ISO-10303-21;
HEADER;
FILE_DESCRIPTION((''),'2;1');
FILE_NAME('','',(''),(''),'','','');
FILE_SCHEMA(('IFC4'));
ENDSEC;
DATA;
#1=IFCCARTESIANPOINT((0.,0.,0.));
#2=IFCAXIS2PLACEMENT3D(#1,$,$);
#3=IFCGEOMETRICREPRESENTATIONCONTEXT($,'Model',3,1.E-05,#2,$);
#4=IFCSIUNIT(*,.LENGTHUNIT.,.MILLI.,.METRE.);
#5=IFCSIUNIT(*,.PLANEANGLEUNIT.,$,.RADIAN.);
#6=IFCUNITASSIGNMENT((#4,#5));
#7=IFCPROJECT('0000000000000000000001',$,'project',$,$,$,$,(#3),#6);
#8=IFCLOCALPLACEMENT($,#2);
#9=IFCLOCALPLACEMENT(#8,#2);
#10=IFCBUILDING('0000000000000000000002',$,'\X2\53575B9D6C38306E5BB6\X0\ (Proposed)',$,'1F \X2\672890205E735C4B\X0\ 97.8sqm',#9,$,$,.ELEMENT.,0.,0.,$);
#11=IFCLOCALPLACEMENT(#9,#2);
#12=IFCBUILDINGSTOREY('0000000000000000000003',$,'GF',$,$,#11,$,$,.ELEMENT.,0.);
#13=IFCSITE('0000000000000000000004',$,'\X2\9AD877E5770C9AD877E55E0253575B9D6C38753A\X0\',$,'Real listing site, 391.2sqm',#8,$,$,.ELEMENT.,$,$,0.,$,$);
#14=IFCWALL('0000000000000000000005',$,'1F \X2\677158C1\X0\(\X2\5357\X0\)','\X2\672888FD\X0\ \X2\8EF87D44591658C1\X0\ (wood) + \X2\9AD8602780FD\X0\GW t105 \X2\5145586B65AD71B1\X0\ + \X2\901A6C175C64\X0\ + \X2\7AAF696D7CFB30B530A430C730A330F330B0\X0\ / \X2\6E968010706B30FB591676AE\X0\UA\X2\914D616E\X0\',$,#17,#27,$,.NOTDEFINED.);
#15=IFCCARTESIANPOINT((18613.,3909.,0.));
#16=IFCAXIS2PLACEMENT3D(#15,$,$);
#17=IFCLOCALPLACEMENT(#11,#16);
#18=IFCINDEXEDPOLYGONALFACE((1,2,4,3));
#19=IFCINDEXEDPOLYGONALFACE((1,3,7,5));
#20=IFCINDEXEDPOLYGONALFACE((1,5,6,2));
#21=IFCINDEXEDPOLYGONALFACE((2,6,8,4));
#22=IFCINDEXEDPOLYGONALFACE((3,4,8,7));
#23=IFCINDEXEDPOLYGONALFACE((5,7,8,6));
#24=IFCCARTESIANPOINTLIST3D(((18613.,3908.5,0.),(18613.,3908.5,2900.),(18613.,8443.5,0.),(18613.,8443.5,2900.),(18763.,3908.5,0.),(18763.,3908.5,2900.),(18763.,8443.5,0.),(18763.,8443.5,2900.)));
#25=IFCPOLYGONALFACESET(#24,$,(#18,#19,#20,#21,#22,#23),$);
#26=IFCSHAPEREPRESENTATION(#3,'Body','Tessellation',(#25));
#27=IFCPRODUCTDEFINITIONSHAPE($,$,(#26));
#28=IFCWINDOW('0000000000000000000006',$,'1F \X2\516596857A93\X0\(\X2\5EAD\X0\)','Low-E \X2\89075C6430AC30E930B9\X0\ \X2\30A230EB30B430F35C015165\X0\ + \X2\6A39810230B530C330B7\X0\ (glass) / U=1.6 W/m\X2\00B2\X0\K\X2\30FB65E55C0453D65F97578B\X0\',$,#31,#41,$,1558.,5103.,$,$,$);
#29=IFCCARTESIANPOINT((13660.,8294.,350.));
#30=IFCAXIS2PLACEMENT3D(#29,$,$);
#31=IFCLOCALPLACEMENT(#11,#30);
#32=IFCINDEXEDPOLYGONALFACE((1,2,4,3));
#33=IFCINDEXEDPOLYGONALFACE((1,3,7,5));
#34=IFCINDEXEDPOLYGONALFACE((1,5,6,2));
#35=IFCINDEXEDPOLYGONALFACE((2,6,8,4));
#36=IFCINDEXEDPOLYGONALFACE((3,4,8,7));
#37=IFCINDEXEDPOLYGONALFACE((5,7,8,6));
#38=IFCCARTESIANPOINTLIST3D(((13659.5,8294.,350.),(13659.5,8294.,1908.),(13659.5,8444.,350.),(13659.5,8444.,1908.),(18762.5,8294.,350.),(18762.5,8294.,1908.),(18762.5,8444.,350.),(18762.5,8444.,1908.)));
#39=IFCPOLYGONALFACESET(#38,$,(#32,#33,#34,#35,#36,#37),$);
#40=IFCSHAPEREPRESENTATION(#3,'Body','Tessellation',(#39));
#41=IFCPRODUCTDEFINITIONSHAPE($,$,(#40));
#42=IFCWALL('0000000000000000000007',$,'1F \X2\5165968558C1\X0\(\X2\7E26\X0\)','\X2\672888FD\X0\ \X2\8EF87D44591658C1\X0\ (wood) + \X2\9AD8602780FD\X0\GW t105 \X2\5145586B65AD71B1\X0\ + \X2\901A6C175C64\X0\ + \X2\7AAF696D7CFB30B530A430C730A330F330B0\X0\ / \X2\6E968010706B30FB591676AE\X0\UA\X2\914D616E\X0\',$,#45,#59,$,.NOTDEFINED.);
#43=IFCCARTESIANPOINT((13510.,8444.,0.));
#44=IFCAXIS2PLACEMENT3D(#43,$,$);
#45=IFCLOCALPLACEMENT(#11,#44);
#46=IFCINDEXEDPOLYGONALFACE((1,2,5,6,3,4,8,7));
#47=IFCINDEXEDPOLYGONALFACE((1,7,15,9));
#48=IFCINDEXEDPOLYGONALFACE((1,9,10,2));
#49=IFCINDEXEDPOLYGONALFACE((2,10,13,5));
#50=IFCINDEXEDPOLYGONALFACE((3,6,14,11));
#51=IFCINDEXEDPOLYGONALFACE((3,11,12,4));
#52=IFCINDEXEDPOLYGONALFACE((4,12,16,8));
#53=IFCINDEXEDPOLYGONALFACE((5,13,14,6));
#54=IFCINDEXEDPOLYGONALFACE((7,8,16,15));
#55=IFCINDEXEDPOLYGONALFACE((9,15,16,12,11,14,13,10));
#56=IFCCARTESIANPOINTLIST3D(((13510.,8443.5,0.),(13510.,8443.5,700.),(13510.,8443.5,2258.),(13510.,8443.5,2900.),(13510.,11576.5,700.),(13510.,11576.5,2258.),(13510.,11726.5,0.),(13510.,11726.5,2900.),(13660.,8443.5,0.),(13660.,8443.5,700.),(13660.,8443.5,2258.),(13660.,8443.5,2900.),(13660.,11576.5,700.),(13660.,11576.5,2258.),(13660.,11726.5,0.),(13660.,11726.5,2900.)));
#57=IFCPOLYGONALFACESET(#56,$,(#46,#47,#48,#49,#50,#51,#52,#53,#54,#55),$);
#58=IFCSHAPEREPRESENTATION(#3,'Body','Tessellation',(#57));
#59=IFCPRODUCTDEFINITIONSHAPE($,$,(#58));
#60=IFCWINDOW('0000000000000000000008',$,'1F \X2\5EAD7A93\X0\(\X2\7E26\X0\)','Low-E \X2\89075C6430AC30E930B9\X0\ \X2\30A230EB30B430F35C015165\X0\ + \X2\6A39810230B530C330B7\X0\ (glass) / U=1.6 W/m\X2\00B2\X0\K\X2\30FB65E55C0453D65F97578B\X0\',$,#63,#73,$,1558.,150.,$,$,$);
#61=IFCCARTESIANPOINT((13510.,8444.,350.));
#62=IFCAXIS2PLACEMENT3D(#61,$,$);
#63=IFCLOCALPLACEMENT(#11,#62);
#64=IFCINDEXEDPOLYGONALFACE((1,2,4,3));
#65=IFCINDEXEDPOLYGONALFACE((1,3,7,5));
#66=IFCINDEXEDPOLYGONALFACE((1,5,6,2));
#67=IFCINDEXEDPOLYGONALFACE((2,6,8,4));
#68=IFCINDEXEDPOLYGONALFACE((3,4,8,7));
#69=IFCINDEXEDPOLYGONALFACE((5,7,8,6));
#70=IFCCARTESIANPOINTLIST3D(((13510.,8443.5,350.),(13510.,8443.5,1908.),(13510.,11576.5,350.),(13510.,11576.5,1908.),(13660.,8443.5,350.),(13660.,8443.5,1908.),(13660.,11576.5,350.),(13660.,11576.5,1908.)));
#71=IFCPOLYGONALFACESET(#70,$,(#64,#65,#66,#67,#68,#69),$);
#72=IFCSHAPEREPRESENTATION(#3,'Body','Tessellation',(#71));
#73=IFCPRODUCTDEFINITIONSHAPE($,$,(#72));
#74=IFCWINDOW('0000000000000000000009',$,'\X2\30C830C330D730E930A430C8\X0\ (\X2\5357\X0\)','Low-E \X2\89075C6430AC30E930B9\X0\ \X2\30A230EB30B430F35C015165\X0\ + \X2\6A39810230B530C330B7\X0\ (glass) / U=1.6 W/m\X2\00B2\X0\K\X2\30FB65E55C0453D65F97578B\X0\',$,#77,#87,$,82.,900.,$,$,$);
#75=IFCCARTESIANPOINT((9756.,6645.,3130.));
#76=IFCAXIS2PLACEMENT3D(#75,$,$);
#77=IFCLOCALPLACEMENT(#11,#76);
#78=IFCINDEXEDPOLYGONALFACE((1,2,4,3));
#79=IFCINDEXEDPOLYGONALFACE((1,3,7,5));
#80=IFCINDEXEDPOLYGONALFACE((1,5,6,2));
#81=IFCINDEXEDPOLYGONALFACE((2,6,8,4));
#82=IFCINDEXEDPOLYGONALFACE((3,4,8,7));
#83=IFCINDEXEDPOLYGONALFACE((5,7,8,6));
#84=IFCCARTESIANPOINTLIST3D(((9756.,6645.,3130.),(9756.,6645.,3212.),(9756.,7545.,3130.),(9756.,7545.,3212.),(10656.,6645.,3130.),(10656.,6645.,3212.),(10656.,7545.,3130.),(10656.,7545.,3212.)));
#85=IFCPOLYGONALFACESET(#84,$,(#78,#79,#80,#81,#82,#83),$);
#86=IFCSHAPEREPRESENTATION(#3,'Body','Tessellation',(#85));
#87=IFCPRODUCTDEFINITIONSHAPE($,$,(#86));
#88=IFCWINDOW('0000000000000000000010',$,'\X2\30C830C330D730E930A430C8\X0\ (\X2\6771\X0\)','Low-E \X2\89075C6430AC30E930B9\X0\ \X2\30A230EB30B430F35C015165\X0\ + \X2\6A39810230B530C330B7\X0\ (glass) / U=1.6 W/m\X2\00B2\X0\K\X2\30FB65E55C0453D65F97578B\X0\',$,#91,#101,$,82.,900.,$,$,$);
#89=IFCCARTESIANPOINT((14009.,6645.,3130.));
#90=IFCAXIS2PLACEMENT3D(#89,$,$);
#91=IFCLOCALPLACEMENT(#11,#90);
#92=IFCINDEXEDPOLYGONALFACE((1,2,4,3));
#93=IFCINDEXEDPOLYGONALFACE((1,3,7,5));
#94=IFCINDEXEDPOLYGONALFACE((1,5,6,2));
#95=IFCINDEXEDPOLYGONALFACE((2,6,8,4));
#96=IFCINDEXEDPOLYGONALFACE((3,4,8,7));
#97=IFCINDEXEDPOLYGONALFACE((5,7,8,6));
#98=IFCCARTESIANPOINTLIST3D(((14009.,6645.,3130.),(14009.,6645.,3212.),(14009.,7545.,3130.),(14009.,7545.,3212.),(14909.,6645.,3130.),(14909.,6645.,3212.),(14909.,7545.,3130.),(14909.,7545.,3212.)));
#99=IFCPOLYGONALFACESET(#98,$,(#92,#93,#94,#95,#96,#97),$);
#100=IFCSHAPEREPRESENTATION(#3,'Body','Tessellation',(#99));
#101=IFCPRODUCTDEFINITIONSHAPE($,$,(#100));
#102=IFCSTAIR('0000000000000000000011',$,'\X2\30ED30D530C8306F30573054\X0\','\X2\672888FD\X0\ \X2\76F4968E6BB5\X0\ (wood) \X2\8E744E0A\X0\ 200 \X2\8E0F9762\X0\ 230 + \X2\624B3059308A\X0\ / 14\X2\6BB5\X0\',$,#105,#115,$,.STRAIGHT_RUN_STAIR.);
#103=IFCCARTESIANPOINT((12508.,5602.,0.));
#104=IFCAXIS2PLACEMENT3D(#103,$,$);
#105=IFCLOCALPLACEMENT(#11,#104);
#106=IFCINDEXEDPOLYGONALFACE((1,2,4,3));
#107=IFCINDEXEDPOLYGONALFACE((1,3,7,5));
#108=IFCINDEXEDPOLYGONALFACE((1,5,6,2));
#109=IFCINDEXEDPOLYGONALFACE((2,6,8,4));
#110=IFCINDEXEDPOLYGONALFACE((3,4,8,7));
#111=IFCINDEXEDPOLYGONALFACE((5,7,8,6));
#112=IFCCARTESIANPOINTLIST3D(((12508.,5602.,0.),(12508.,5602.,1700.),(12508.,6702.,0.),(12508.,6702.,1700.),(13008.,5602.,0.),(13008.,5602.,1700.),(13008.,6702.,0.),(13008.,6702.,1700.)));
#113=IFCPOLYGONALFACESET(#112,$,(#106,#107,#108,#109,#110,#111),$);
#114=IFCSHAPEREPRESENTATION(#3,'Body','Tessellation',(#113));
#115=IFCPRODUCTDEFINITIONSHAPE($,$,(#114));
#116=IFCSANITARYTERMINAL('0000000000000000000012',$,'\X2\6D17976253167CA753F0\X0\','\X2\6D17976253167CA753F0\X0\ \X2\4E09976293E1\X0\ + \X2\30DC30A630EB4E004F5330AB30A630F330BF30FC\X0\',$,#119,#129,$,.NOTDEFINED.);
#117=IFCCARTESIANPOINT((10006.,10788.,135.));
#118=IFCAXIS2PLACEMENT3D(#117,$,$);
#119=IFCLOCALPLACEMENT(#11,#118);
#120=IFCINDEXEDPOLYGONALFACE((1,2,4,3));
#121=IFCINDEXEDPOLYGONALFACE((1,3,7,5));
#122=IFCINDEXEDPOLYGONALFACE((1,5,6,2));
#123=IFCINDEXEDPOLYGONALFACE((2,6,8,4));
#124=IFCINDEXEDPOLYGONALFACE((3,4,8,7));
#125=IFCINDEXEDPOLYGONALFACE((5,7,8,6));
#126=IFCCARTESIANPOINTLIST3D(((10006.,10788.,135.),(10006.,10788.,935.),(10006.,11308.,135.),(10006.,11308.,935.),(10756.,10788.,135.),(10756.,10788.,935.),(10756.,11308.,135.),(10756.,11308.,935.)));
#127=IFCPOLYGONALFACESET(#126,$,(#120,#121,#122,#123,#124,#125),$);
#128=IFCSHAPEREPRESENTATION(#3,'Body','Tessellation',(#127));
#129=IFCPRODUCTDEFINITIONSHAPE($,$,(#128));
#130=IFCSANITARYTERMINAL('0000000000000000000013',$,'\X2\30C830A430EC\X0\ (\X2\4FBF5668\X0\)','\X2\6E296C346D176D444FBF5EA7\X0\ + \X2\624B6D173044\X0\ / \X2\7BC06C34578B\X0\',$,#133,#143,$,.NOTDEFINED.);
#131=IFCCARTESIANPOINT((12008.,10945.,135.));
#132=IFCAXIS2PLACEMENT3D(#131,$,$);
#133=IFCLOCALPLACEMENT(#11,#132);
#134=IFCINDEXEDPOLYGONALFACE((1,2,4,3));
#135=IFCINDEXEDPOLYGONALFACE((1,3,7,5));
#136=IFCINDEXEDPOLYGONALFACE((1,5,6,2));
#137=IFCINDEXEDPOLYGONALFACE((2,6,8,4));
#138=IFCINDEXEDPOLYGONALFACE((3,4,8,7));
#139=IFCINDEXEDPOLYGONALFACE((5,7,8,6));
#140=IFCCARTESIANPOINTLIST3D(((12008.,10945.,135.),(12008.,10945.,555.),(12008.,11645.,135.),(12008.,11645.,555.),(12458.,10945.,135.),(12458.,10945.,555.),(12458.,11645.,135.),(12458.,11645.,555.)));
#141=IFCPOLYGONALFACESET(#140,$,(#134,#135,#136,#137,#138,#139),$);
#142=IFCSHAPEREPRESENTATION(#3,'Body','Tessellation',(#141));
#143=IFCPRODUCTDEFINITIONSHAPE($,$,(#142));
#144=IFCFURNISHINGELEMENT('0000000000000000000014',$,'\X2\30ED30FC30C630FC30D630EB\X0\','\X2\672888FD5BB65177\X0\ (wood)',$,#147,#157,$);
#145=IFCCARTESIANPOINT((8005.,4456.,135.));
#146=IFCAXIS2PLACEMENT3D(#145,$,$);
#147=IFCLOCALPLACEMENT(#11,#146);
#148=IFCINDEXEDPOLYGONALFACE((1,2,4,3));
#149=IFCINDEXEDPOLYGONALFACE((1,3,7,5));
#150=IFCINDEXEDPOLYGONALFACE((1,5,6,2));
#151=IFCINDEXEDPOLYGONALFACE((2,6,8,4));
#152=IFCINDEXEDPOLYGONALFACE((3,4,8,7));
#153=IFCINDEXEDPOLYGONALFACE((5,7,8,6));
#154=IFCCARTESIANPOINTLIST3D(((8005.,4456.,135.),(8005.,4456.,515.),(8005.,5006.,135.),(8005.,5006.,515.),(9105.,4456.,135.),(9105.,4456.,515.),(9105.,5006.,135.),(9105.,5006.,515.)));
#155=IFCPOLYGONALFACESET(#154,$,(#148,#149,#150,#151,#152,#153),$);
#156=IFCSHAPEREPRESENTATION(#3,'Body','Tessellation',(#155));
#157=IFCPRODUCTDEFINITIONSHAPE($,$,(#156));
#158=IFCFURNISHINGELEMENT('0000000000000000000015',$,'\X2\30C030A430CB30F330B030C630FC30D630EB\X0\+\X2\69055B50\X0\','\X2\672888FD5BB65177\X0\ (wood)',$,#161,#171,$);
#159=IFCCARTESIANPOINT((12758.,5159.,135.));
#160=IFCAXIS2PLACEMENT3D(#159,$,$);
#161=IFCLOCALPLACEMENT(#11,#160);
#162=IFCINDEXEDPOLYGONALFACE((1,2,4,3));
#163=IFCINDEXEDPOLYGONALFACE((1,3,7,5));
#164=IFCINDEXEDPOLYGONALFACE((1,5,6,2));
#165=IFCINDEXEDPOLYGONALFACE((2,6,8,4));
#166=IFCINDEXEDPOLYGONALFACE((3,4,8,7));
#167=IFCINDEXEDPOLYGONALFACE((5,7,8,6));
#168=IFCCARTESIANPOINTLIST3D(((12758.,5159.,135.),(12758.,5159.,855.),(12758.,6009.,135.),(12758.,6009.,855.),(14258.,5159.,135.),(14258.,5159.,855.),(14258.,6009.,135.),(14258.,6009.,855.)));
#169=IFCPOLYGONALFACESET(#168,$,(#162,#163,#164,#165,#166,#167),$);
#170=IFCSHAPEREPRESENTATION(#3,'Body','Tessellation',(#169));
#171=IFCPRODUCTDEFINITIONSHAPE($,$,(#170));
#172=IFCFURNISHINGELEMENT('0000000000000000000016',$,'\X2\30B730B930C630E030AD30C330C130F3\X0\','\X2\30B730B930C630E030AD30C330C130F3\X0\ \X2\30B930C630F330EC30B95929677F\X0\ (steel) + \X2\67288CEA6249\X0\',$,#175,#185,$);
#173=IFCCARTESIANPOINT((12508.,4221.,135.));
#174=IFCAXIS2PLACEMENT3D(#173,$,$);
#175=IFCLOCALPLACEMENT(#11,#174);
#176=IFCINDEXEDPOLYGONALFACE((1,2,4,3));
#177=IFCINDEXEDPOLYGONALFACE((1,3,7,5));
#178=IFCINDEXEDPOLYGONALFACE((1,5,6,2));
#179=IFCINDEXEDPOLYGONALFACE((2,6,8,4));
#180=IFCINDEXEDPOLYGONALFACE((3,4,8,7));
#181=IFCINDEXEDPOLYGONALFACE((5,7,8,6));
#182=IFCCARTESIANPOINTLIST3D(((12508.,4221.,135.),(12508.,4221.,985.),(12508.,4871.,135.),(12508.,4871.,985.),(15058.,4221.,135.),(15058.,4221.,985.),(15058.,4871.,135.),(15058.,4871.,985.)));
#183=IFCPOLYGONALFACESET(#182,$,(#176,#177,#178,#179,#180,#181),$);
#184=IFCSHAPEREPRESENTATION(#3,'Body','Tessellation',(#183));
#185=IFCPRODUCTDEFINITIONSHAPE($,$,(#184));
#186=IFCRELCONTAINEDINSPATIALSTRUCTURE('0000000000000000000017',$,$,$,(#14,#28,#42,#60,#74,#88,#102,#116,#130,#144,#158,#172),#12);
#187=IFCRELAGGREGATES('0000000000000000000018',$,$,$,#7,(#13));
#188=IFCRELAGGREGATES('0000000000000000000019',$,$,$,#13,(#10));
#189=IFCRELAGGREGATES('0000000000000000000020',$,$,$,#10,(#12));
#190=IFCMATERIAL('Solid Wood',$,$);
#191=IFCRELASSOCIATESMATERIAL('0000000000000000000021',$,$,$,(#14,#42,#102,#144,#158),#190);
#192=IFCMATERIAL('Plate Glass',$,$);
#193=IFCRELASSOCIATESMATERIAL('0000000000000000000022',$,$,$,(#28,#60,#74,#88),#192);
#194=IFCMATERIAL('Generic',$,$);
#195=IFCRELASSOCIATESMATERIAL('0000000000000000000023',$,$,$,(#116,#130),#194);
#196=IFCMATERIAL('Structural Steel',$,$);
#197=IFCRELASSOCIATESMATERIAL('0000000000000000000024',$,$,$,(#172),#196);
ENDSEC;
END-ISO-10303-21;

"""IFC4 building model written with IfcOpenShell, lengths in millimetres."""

from ifc_helpers import new_model, si_unit, frame, frame_2d, origin, place, context, project, spatial, rectangle, extrude, material, element, fill, save


model = new_model("IFC4")

# Units and contexts
model_context = context("Model", 3, precision=1e-05, world=origin())
ifc_project = project(units=[si_unit("LENGTHUNIT", "METRE", prefix="MILLI"), si_unit("PLANEANGLEUNIT", "RADIAN")], contexts=[model_context])

# Site, building, storey
site_placement = place(None, origin())
site = spatial("IfcSite", under=ifc_project, at=site_placement, Name="高知県高知市南宝永町", ObjectType="Real listing site, 391.2sqm", CompositionType="ELEMENT", RefElevation=0.0)
building_placement = place(site_placement, origin())
building = spatial("IfcBuilding", under=site, at=building_placement, Name="南宝永の家 (Proposed)", ObjectType="1F 木造平屋 97.8sqm", CompositionType="ELEMENT", ElevationOfRefHeight=0.0, ElevationOfTerrain=0.0)
storey_placement = place(building_placement, origin())
storey = spatial("IfcBuildingStorey", under=building, at=storey_placement, Name="GF", CompositionType="ELEMENT", Elevation=0.0)

# Shared definitions
ifc_material_1 = material(Name="Solid Wood")

# Wall, opening, window
wall_1_placement = place(storey_placement, frame((18613.0, 3909.0, 0.0)))
wall_1 = element("IfcWall", 1, at=wall_1_placement, inside=storey, material=ifc_material_1, Name="1F 東壁(南)", Description="木製 軸組外壁 (wood) + 高性能GW t105 充填断熱 + 通気層 + 窯業系サイディング / 準耐火・外皮UA配慮", PredefinedType="NOTDEFINED", context=model_context, shape_type="SweptSolid", body=[
    extrude(rectangle(XDim=150.0, YDim=4535.0, at=frame_2d((75.0, 2267.0))), frame((18613.0, 3909.0, 0.0)), (0.0, 0.0, 1.0), 2900.0),
])
opening_1_placement = place(storey_placement, frame((13660.0, 8294.0, 350.0)))
opening_1 = element("IfcOpeningElement", 2, at=opening_1_placement, cuts=wall_1, PredefinedType="NOTDEFINED", context=model_context, shape_type="SweptSolid", body=[
    extrude(rectangle(XDim=5103.0, YDim=150.0, at=frame_2d((2551.0, 75.0))), frame((13660.0, 8294.0, 350.0)), (0.0, 0.0, 1.0), 1558.0),
])
ifc_material_2 = material(Name="Plate Glass")
window_1_placement = place(storey_placement, frame((13660.0, 8294.0, 350.0)))
window_1 = element("IfcWindow", 3, at=window_1_placement, inside=storey, material=ifc_material_2, Name="1F 入隅窓(庭)", Description="Low-E 複層ガラス アルゴン封入 + 樹脂サッシ (glass) / U=1.6 W/m²K・日射取得型", OverallHeight=1558.0, OverallWidth=5103.0, context=model_context, shape_type="SweptSolid", body=[
    extrude(rectangle(XDim=5103.0, YDim=150.0, at=frame_2d((2551.0, 75.0))), frame((13660.0, 8294.0, 350.0)), (0.0, 0.0, 1.0), 1558.0),
])
fill(opening_1, window_1)

# Wall, opening, window
wall_2_placement = place(storey_placement, frame((13510.0, 8444.0, 0.0)))
wall_2 = element("IfcWall", 4, at=wall_2_placement, inside=storey, material=ifc_material_1, Name="1F 入隅壁(縦)", Description="木製 軸組外壁 (wood) + 高性能GW t105 充填断熱 + 通気層 + 窯業系サイディング / 準耐火・外皮UA配慮", PredefinedType="NOTDEFINED", context=model_context, shape_type="SweptSolid", body=[
    extrude(rectangle(XDim=150.0, YDim=3283.0, at=frame_2d((75.0, 1641.0))), frame((13510.0, 8444.0, 0.0)), (0.0, 0.0, 1.0), 2900.0),
])
opening_2_placement = place(storey_placement, frame((13510.0, 8444.0, 350.0)))
opening_2 = element("IfcOpeningElement", 5, at=opening_2_placement, cuts=wall_2, PredefinedType="NOTDEFINED", context=model_context, shape_type="SweptSolid", body=[
    extrude(rectangle(XDim=150.0, YDim=3133.0, at=frame_2d((75.0, 1566.0))), frame((13510.0, 8444.0, 350.0)), (0.0, 0.0, 1.0), 1558.0),
])
window_2_placement = place(storey_placement, frame((13510.0, 8444.0, 350.0)))
window_2 = element("IfcWindow", 6, at=window_2_placement, inside=storey, material=ifc_material_2, Name="1F 庭窓(縦)", Description="Low-E 複層ガラス アルゴン封入 + 樹脂サッシ (glass) / U=1.6 W/m²K・日射取得型", OverallHeight=1558.0, OverallWidth=150.0, context=model_context, shape_type="SweptSolid", body=[
    extrude(rectangle(XDim=150.0, YDim=3133.0, at=frame_2d((75.0, 1566.0))), frame((13510.0, 8444.0, 350.0)), (0.0, 0.0, 1.0), 1558.0),
])
fill(opening_2, window_2)

# Windows
window_3_placement = place(storey_placement, frame((9756.0, 6645.0, 3130.0)))
element("IfcWindow", 7, at=window_3_placement, inside=storey, material=ifc_material_2, Name="トップライト (南)", Description="Low-E 複層ガラス アルゴン封入 + 樹脂サッシ (glass) / U=1.6 W/m²K・日射取得型", OverallHeight=82.0, OverallWidth=900.0, context=model_context, shape_type="SweptSolid", body=[
    extrude(rectangle(XDim=900.0, YDim=900.0, at=frame_2d((450.0, 450.0))), frame((9756.0, 6645.0, 3130.0)), (0.0, 0.0, 1.0), 82.0),
])
window_4_placement = place(storey_placement, frame((14009.0, 6645.0, 3130.0)))
element("IfcWindow", 8, at=window_4_placement, inside=storey, material=ifc_material_2, Name="トップライト (東)", Description="Low-E 複層ガラス アルゴン封入 + 樹脂サッシ (glass) / U=1.6 W/m²K・日射取得型", OverallHeight=82.0, OverallWidth=900.0, context=model_context, shape_type="SweptSolid", body=[
    extrude(rectangle(XDim=900.0, YDim=900.0, at=frame_2d((450.0, 450.0))), frame((14009.0, 6645.0, 3130.0)), (0.0, 0.0, 1.0), 82.0),
])

# Stair
stair_placement = place(storey_placement, frame((12508.0, 5602.0, 0.0)))
element("IfcStair", 9, at=stair_placement, inside=storey, material=ifc_material_1, Name="ロフトはしご", Description="木製 直階段 (wood) 蹴上 200 踏面 230 + 手すり / 14段", PredefinedType="STRAIGHT_RUN_STAIR", context=model_context, shape_type="SweptSolid", body=[
    extrude(rectangle(XDim=500.0, YDim=1100.0, at=frame_2d((250.0, 550.0))), frame((12508.0, 5602.0, 0.0)), (0.0, 0.0, 1.0), 1700.0),
])

# Sanitary terminals
ifc_material_3 = material(Name="Generic")
sanitary_terminal_1_placement = place(storey_placement, frame((10006.0, 10788.0, 135.0)))
element("IfcSanitaryTerminal", 10, at=sanitary_terminal_1_placement, inside=storey, material=ifc_material_3, Name="洗面化粧台", Description="洗面化粧台 三面鏡 + ボウル一体カウンター", PredefinedType="NOTDEFINED", context=model_context, shape_type="SweptSolid", body=[
    extrude(rectangle(XDim=750.0, YDim=520.0, at=frame_2d((375.0, 260.0))), frame((10006.0, 10788.0, 135.0)), (0.0, 0.0, 1.0), 800.0),
])
sanitary_terminal_2_placement = place(storey_placement, frame((12008.0, 10945.0, 135.0)))
element("IfcSanitaryTerminal", 11, at=sanitary_terminal_2_placement, inside=storey, material=ifc_material_3, Name="トイレ (便器)", Description="温水洗浄便座 + 手洗い / 節水型", PredefinedType="NOTDEFINED", context=model_context, shape_type="SweptSolid", body=[
    extrude(rectangle(XDim=450.0, YDim=700.0, at=frame_2d((225.0, 350.0))), frame((12008.0, 10945.0, 135.0)), (0.0, 0.0, 1.0), 420.0),
])

# Furnishing elements
furnishing_1_placement = place(storey_placement, frame((8005.0, 4456.0, 135.0)))
element("IfcFurnishingElement", 12, at=furnishing_1_placement, inside=storey, material=ifc_material_1, Name="ローテーブル", Description="木製家具 (wood)", context=model_context, shape_type="SweptSolid", body=[
    extrude(rectangle(XDim=1100.0, YDim=550.0, at=frame_2d((550.0, 275.0))), frame((8005.0, 4456.0, 135.0)), (0.0, 0.0, 1.0), 380.0),
])
furnishing_2_placement = place(storey_placement, frame((12758.0, 5159.0, 135.0)))
element("IfcFurnishingElement", 13, at=furnishing_2_placement, inside=storey, material=ifc_material_1, Name="ダイニングテーブル+椅子", Description="木製家具 (wood)", context=model_context, shape_type="SweptSolid", body=[
    extrude(rectangle(XDim=1500.0, YDim=850.0, at=frame_2d((750.0, 425.0))), frame((12758.0, 5159.0, 135.0)), (0.0, 0.0, 1.0), 720.0),
])
ifc_material_4 = material(Name="Structural Steel")
furnishing_3_placement = place(storey_placement, frame((12508.0, 4221.0, 135.0)))
element("IfcFurnishingElement", 14, at=furnishing_3_placement, inside=storey, material=ifc_material_4, Name="システムキッチン", Description="システムキッチン ステンレス天板 (steel) + 木質扉", context=model_context, shape_type="SweptSolid", body=[
    extrude(rectangle(XDim=2550.0, YDim=650.0, at=frame_2d((1275.0, 325.0))), frame((12508.0, 4221.0, 135.0)), (0.0, 0.0, 1.0), 850.0),
])

save(model, "model.ifc")
